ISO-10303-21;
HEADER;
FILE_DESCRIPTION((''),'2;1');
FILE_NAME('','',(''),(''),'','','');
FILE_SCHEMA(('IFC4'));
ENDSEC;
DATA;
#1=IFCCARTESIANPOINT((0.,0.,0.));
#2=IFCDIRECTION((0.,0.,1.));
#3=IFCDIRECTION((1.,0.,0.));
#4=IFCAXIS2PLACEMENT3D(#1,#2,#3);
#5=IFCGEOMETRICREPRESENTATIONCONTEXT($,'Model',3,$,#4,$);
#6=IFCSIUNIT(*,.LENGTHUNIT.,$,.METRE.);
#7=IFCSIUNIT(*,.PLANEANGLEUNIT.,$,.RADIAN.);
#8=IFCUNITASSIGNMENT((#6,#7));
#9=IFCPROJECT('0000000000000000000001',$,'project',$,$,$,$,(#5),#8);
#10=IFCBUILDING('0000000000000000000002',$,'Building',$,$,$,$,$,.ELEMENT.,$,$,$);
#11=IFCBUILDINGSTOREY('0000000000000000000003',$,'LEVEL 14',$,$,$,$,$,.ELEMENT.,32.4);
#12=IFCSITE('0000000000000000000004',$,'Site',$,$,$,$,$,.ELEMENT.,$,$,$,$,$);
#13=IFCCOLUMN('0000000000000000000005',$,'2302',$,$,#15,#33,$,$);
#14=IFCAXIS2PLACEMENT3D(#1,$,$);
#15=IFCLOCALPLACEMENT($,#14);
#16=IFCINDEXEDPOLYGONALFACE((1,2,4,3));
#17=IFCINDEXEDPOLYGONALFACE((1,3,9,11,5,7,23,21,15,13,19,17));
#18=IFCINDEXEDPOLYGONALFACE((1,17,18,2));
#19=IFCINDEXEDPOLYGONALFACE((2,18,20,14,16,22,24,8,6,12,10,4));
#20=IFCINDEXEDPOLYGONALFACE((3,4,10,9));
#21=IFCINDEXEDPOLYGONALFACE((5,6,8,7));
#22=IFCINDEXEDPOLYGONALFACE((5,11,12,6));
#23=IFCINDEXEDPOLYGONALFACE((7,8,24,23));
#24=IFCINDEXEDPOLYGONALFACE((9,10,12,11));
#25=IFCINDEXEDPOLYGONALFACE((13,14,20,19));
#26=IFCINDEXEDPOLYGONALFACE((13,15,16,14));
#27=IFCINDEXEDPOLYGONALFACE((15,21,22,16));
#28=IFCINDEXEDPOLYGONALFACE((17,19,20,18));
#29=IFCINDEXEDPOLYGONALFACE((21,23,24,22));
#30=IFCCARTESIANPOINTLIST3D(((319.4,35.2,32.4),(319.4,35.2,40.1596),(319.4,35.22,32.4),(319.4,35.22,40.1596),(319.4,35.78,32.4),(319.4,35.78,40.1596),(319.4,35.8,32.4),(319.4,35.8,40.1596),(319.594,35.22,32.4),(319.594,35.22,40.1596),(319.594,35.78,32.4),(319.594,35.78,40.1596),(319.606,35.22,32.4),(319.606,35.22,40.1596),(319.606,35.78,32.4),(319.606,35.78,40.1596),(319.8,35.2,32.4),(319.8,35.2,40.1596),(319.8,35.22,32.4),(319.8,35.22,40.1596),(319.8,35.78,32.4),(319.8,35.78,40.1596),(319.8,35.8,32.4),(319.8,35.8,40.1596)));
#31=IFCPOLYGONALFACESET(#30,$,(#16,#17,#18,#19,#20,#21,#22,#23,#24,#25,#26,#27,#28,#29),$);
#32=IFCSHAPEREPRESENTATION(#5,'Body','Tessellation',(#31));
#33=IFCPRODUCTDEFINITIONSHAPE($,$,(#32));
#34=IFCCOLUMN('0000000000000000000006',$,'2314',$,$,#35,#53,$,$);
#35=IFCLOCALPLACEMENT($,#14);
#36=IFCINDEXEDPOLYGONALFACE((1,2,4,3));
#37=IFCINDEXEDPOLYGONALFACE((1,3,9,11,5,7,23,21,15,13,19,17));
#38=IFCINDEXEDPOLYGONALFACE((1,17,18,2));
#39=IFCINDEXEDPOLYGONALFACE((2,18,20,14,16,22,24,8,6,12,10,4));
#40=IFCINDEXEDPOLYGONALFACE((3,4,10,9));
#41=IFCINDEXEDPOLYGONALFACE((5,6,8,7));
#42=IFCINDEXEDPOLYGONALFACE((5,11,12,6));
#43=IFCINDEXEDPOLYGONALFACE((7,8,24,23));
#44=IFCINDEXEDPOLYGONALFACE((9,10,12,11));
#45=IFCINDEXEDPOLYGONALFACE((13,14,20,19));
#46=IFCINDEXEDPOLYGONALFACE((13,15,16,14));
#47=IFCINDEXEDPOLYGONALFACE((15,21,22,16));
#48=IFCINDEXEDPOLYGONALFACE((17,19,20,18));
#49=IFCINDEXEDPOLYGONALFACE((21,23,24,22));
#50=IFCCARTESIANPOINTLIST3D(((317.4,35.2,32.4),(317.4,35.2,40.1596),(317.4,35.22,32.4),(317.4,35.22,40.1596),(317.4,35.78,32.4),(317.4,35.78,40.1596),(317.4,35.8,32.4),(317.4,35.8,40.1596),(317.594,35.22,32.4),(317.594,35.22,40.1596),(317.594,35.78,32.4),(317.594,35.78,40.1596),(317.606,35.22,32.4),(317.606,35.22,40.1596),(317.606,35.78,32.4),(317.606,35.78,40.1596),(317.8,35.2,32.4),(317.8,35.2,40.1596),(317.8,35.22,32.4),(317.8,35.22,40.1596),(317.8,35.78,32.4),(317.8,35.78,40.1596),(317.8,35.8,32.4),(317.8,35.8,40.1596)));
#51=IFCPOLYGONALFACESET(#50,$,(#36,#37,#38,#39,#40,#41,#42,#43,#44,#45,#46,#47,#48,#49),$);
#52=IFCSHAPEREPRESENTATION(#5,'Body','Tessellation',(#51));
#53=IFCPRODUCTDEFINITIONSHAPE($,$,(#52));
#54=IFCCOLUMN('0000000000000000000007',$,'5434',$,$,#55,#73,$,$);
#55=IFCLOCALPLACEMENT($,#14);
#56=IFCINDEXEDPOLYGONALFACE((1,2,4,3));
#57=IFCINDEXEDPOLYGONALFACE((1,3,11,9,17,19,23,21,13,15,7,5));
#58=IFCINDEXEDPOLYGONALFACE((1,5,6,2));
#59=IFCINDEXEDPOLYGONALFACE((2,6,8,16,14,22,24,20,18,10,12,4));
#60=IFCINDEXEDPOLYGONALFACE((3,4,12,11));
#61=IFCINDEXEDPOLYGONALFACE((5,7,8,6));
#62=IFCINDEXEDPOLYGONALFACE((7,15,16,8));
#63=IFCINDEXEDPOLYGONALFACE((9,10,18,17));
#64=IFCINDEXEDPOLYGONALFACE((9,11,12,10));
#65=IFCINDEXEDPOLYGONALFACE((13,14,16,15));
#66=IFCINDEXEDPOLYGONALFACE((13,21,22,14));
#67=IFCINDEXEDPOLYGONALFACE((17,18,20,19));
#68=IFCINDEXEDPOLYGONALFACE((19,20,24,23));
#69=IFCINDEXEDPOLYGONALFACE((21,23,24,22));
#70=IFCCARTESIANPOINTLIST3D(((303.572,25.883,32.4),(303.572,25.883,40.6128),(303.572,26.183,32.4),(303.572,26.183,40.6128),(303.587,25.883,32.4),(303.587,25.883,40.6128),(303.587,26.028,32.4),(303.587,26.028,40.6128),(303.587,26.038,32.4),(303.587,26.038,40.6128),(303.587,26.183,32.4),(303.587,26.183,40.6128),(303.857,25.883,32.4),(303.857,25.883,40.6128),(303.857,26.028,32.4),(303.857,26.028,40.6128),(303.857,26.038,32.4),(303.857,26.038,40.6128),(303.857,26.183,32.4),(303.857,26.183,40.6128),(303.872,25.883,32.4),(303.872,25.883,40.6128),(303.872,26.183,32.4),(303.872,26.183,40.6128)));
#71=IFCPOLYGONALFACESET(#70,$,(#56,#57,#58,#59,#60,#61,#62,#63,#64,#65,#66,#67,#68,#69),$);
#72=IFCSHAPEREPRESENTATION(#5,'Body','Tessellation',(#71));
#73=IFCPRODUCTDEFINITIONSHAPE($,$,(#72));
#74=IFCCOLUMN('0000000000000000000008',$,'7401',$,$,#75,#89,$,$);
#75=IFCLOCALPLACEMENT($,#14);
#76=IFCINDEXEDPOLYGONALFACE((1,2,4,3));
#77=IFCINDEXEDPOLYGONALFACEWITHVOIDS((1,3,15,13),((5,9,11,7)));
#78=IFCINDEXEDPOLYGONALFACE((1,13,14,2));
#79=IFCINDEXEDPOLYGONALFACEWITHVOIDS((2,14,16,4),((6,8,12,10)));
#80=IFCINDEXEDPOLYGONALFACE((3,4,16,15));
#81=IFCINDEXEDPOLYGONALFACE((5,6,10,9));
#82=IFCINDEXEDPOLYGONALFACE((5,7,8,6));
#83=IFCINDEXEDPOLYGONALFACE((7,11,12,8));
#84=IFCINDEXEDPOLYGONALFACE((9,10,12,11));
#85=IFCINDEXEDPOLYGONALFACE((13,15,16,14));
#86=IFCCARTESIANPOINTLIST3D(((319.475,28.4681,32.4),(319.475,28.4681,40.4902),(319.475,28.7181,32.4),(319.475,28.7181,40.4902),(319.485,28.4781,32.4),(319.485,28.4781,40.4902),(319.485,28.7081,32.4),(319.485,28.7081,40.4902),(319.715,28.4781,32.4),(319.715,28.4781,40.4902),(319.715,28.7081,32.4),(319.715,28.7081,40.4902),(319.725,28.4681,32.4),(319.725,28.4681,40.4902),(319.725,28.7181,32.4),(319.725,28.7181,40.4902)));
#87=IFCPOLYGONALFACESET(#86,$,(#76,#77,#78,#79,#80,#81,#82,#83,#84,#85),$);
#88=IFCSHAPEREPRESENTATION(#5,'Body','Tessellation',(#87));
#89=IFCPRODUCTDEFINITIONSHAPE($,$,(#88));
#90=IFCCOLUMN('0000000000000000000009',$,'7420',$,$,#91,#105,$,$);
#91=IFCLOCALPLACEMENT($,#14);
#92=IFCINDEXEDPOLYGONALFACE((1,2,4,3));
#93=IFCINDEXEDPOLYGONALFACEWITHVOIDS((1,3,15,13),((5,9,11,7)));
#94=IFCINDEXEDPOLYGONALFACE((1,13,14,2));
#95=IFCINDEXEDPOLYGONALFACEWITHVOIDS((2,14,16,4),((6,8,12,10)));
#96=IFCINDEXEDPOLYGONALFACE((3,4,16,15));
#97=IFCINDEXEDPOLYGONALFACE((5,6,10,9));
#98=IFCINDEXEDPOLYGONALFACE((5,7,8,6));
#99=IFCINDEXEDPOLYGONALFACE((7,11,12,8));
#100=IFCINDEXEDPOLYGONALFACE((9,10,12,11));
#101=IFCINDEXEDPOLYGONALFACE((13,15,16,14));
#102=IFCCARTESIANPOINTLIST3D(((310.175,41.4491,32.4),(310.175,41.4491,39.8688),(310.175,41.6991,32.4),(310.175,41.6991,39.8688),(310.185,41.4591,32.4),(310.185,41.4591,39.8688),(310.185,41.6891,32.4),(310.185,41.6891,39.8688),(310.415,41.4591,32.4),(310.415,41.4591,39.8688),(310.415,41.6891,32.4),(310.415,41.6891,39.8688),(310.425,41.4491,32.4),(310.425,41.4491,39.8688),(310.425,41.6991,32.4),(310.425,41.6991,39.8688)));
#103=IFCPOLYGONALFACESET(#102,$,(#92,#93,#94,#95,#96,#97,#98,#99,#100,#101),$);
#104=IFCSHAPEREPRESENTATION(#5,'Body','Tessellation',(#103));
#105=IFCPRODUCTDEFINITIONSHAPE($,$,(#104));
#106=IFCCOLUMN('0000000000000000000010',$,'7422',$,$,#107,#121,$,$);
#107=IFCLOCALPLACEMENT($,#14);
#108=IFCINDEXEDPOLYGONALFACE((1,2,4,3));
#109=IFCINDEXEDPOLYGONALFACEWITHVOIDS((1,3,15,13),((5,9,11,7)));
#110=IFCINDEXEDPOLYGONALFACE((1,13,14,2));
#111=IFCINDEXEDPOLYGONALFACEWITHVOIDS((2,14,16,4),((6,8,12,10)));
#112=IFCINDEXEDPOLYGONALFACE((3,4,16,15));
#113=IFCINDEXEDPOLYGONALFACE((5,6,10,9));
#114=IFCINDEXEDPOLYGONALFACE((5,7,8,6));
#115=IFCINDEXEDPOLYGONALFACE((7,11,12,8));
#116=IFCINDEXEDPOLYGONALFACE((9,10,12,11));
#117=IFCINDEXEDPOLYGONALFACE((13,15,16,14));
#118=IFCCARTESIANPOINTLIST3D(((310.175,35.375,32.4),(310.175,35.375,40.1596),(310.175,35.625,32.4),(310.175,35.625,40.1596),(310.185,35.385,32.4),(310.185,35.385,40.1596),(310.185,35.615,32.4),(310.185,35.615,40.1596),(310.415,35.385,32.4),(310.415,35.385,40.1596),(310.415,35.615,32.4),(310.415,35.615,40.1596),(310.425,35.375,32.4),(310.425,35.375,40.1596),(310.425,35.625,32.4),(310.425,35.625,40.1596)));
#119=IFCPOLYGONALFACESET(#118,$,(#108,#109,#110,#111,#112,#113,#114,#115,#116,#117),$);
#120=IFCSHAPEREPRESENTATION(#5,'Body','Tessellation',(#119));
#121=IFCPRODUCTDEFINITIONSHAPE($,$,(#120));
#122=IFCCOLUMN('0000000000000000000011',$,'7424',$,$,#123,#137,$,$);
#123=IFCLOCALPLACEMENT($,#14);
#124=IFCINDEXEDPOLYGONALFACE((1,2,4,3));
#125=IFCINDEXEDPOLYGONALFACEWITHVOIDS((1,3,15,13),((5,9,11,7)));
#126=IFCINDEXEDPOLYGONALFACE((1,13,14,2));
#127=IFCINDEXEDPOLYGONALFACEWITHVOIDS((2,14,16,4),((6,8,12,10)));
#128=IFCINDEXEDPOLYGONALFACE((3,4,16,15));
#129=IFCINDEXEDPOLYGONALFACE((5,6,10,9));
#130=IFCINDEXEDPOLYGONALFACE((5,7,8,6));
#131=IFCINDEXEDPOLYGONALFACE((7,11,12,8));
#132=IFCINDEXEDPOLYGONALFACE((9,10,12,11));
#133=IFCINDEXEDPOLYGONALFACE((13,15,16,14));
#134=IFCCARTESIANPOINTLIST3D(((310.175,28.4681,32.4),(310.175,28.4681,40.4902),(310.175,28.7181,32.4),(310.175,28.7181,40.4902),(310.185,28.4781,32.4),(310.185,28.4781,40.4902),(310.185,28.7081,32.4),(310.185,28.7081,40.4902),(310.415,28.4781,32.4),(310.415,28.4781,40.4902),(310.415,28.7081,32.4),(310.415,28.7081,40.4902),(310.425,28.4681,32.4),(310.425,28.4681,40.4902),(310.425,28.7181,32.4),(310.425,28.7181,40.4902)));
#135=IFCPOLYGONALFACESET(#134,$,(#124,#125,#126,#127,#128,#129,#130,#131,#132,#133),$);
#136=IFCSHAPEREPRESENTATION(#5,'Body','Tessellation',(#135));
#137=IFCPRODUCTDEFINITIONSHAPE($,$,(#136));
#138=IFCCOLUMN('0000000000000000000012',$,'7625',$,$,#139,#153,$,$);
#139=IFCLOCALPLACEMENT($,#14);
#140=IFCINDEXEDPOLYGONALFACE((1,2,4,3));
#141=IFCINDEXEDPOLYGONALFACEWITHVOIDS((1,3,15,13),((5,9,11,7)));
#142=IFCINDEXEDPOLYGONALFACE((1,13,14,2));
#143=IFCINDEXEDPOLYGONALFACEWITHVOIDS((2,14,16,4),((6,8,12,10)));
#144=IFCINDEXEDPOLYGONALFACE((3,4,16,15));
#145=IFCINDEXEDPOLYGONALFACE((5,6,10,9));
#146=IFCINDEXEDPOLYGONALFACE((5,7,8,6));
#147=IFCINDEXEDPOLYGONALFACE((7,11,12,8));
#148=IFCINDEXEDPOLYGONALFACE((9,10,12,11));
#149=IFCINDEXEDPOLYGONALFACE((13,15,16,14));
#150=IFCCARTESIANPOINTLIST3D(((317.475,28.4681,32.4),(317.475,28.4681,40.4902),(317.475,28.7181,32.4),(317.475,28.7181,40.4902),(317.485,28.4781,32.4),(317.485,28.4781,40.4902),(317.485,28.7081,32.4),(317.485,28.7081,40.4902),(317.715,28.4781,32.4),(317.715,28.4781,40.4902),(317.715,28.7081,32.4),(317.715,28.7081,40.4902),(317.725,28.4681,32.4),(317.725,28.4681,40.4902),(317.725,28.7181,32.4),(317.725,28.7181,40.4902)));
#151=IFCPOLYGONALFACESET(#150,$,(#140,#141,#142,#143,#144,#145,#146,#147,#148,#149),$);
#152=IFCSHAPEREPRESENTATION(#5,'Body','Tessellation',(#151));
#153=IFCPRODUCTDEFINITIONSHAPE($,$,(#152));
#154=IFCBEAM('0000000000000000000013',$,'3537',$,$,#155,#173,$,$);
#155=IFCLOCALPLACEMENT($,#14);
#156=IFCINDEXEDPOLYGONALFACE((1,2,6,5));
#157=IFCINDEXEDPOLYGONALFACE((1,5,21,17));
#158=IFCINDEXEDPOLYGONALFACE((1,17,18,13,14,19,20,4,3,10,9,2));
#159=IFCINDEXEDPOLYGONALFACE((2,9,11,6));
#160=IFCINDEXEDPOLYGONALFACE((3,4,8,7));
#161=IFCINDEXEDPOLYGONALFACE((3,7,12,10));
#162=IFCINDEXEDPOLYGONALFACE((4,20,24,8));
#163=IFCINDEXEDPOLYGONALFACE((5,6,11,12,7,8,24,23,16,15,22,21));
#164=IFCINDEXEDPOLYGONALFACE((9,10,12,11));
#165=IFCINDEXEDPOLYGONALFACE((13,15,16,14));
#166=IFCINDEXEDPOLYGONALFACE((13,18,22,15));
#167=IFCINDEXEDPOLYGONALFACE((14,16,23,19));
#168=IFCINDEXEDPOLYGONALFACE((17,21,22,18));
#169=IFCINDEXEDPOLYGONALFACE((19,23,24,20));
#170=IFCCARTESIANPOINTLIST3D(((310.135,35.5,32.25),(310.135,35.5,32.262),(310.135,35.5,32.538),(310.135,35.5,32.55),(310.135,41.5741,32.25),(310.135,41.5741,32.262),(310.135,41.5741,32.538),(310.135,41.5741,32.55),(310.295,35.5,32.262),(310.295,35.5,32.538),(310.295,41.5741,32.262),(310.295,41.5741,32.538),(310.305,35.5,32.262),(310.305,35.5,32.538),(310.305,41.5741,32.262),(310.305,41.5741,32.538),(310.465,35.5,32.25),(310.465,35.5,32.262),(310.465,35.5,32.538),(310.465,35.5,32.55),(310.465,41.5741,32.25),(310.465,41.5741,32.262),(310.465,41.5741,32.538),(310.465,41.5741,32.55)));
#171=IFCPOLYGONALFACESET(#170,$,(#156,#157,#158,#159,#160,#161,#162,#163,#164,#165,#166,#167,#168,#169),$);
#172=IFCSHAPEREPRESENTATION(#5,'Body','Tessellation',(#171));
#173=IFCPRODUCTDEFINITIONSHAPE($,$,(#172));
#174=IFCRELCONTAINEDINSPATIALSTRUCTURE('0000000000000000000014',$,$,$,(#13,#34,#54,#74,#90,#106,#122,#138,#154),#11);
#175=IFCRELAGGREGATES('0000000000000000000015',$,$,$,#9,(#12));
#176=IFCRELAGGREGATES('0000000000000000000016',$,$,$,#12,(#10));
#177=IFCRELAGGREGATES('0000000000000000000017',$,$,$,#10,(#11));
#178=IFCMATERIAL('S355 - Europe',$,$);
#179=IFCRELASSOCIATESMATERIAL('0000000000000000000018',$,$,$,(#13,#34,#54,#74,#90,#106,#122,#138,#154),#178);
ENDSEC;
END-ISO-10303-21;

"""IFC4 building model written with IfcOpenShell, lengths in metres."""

from ifc_helpers import new_model, si_unit, frame, origin_with_axes, origin_2d_with_axis, place, context, project, spatial, hollow_rectangle, i_section, extrude, material, material_profile, profile_set, profile_usage, element, save


model = new_model("IFC4")

# Units and contexts
model_context = context("Model", 3, world=origin_with_axes())
ifc_project = project(units=[si_unit("LENGTHUNIT", "METRE"), si_unit("PLANEANGLEUNIT", "RADIAN")], contexts=[model_context])

# Site, building, storey
site = spatial("IfcSite", under=ifc_project, Name="Site", CompositionType="ELEMENT")
building = spatial("IfcBuilding", under=site, Name="Building", CompositionType="ELEMENT")
storey = spatial("IfcBuildingStorey", under=building, Name="LEVEL 14", CompositionType="ELEMENT", Elevation=32.4)

# Columns
ifc_material = material(Name="S355 - Europe")
ifc_material_profile_1 = material_profile(ifc_material, i_section(OverallWidth=0.4, OverallDepth=0.6, WebThickness=0.012, FlangeThickness=0.02, at=origin_2d_with_axis()))
ifc_profile_set_1 = profile_set([ifc_material_profile_1])
ifc_profile_usage_1 = profile_usage(ifc_profile_set_1, cardinal=10)
column_1_placement = place(None, frame((319.6, 35.5, 32.4), z_axis=(0.0, 0.0, 1.0), x_axis=(1.0, 0.0, 0.0)))
element("IfcColumn", 1, at=column_1_placement, inside=storey, material=ifc_profile_usage_1, Name="2302", context=model_context, shape_type="SweptSolid", body=[
    extrude(i_section(OverallWidth=0.4, OverallDepth=0.6, WebThickness=0.012, FlangeThickness=0.02, at=origin_2d_with_axis()), origin_with_axes(), (0.0, 0.0, 1.0), 7.7596),
])
ifc_material_profile_2 = material_profile(ifc_material, i_section(OverallWidth=0.4, OverallDepth=0.6, WebThickness=0.012, FlangeThickness=0.02, at=origin_2d_with_axis()))
ifc_profile_set_2 = profile_set([ifc_material_profile_2])
ifc_profile_usage_2 = profile_usage(ifc_profile_set_2, cardinal=10)
column_2_placement = place(None, frame((317.6, 35.5, 32.4), z_axis=(0.0, 0.0, 1.0), x_axis=(1.0, 0.0, 0.0)))
element("IfcColumn", 2, at=column_2_placement, inside=storey, material=ifc_profile_usage_2, Name="2314", context=model_context, shape_type="SweptSolid", body=[
    extrude(i_section(OverallWidth=0.4, OverallDepth=0.6, WebThickness=0.012, FlangeThickness=0.02, at=origin_2d_with_axis()), origin_with_axes(), (0.0, 0.0, 1.0), 7.7596),
])
ifc_material_profile_3 = material_profile(ifc_material, i_section(OverallWidth=0.3, OverallDepth=0.3, WebThickness=0.01, FlangeThickness=0.015, at=origin_2d_with_axis()))
ifc_profile_set_3 = profile_set([ifc_material_profile_3])
ifc_profile_usage_3 = profile_usage(ifc_profile_set_3, cardinal=10)
column_3_placement = place(None, frame((303.722, 26.033, 32.4), z_axis=(0.0, 0.0, 1.0), x_axis=(0.0, -1.0, 0.0)))
element("IfcColumn", 3, at=column_3_placement, inside=storey, material=ifc_profile_usage_3, Name="5434", context=model_context, shape_type="SweptSolid", body=[
    extrude(i_section(OverallWidth=0.3, OverallDepth=0.3, WebThickness=0.01, FlangeThickness=0.015, at=origin_2d_with_axis()), origin_with_axes(), (0.0, 0.0, 1.0), 8.2128),
])
ifc_material_profile_4 = material_profile(ifc_material, hollow_rectangle(XDim=0.25, YDim=0.25, WallThickness=0.01, at=origin_2d_with_axis()))
ifc_profile_set_4 = profile_set([ifc_material_profile_4])
ifc_profile_usage_4 = profile_usage(ifc_profile_set_4, cardinal=10)
column_4_placement = place(None, frame((319.6, 28.5931, 32.4), z_axis=(0.0, 0.0, 1.0), x_axis=(0.0, -1.0, 0.0)))
element("IfcColumn", 4, at=column_4_placement, inside=storey, material=ifc_profile_usage_4, Name="7401", context=model_context, shape_type="SweptSolid", body=[
    extrude(hollow_rectangle(XDim=0.25, YDim=0.25, WallThickness=0.01, at=origin_2d_with_axis()), origin_with_axes(), (0.0, 0.0, 1.0), 8.0902),
])
ifc_material_profile_5 = material_profile(ifc_material, hollow_rectangle(XDim=0.25, YDim=0.25, WallThickness=0.01, at=origin_2d_with_axis()))
ifc_profile_set_5 = profile_set([ifc_material_profile_5])
ifc_profile_usage_5 = profile_usage(ifc_profile_set_5, cardinal=10)
column_5_placement = place(None, frame((310.3, 41.5741, 32.4), z_axis=(0.0, 0.0, 1.0), x_axis=(0.0, -1.0, 0.0)))
element("IfcColumn", 5, at=column_5_placement, inside=storey, material=ifc_profile_usage_5, Name="7420", context=model_context, shape_type="SweptSolid", body=[
    extrude(hollow_rectangle(XDim=0.25, YDim=0.25, WallThickness=0.01, at=origin_2d_with_axis()), origin_with_axes(), (0.0, 0.0, 1.0), 7.4688),
])
ifc_material_profile_6 = material_profile(ifc_material, hollow_rectangle(XDim=0.25, YDim=0.25, WallThickness=0.01, at=origin_2d_with_axis()))
ifc_profile_set_6 = profile_set([ifc_material_profile_6])
ifc_profile_usage_6 = profile_usage(ifc_profile_set_6, cardinal=10)
column_6_placement = place(None, frame((310.3, 35.5, 32.4), z_axis=(0.0, 0.0, 1.0), x_axis=(0.0, -1.0, 0.0)))
element("IfcColumn", 6, at=column_6_placement, inside=storey, material=ifc_profile_usage_6, Name="7422", context=model_context, shape_type="SweptSolid", body=[
    extrude(hollow_rectangle(XDim=0.25, YDim=0.25, WallThickness=0.01, at=origin_2d_with_axis()), origin_with_axes(), (0.0, 0.0, 1.0), 7.7596),
])
ifc_material_profile_7 = material_profile(ifc_material, hollow_rectangle(XDim=0.25, YDim=0.25, WallThickness=0.01, at=origin_2d_with_axis()))
ifc_profile_set_7 = profile_set([ifc_material_profile_7])
ifc_profile_usage_7 = profile_usage(ifc_profile_set_7, cardinal=10)
column_7_placement = place(None, frame((310.3, 28.5931, 32.4), z_axis=(0.0, 0.0, 1.0), x_axis=(0.0, -1.0, 0.0)))
element("IfcColumn", 7, at=column_7_placement, inside=storey, material=ifc_profile_usage_7, Name="7424", context=model_context, shape_type="SweptSolid", body=[
    extrude(hollow_rectangle(XDim=0.25, YDim=0.25, WallThickness=0.01, at=origin_2d_with_axis()), origin_with_axes(), (0.0, 0.0, 1.0), 8.0902),
])
ifc_material_profile_8 = material_profile(ifc_material, hollow_rectangle(XDim=0.25, YDim=0.25, WallThickness=0.01, at=origin_2d_with_axis()))
ifc_profile_set_8 = profile_set([ifc_material_profile_8])
ifc_profile_usage_8 = profile_usage(ifc_profile_set_8, cardinal=10)
column_8_placement = place(None, frame((317.6, 28.5931, 32.4), z_axis=(0.0, 0.0, 1.0), x_axis=(0.0, -1.0, 0.0)))
element("IfcColumn", 8, at=column_8_placement, inside=storey, material=ifc_profile_usage_8, Name="7625", context=model_context, shape_type="SweptSolid", body=[
    extrude(hollow_rectangle(XDim=0.25, YDim=0.25, WallThickness=0.01, at=origin_2d_with_axis()), origin_with_axes(), (0.0, 0.0, 1.0), 8.0902),
])

# Beam
ifc_material_profile_9 = material_profile(ifc_material, i_section(OverallWidth=0.33, OverallDepth=0.3, WebThickness=0.01, FlangeThickness=0.012, at=origin_2d_with_axis()))
ifc_profile_set_9 = profile_set([ifc_material_profile_9])
ifc_profile_usage_9 = profile_usage(ifc_profile_set_9, cardinal=10)
beam_1_placement = place(None, frame((310.3, 41.5741, 32.4), z_axis=(0.0, -1.0, 0.0), x_axis=(1.0, 0.0, 0.0)))
element("IfcBeam", 9, at=beam_1_placement, inside=storey, material=ifc_profile_usage_9, Name="3537", context=model_context, shape_type="SweptSolid", body=[
    extrude(i_section(OverallWidth=0.33, OverallDepth=0.3, WebThickness=0.01, FlangeThickness=0.012, at=origin_2d_with_axis()), origin_with_axes(), (0.0, 0.0, 1.0), 6.0741),
])

save(model, "model.ifc")
